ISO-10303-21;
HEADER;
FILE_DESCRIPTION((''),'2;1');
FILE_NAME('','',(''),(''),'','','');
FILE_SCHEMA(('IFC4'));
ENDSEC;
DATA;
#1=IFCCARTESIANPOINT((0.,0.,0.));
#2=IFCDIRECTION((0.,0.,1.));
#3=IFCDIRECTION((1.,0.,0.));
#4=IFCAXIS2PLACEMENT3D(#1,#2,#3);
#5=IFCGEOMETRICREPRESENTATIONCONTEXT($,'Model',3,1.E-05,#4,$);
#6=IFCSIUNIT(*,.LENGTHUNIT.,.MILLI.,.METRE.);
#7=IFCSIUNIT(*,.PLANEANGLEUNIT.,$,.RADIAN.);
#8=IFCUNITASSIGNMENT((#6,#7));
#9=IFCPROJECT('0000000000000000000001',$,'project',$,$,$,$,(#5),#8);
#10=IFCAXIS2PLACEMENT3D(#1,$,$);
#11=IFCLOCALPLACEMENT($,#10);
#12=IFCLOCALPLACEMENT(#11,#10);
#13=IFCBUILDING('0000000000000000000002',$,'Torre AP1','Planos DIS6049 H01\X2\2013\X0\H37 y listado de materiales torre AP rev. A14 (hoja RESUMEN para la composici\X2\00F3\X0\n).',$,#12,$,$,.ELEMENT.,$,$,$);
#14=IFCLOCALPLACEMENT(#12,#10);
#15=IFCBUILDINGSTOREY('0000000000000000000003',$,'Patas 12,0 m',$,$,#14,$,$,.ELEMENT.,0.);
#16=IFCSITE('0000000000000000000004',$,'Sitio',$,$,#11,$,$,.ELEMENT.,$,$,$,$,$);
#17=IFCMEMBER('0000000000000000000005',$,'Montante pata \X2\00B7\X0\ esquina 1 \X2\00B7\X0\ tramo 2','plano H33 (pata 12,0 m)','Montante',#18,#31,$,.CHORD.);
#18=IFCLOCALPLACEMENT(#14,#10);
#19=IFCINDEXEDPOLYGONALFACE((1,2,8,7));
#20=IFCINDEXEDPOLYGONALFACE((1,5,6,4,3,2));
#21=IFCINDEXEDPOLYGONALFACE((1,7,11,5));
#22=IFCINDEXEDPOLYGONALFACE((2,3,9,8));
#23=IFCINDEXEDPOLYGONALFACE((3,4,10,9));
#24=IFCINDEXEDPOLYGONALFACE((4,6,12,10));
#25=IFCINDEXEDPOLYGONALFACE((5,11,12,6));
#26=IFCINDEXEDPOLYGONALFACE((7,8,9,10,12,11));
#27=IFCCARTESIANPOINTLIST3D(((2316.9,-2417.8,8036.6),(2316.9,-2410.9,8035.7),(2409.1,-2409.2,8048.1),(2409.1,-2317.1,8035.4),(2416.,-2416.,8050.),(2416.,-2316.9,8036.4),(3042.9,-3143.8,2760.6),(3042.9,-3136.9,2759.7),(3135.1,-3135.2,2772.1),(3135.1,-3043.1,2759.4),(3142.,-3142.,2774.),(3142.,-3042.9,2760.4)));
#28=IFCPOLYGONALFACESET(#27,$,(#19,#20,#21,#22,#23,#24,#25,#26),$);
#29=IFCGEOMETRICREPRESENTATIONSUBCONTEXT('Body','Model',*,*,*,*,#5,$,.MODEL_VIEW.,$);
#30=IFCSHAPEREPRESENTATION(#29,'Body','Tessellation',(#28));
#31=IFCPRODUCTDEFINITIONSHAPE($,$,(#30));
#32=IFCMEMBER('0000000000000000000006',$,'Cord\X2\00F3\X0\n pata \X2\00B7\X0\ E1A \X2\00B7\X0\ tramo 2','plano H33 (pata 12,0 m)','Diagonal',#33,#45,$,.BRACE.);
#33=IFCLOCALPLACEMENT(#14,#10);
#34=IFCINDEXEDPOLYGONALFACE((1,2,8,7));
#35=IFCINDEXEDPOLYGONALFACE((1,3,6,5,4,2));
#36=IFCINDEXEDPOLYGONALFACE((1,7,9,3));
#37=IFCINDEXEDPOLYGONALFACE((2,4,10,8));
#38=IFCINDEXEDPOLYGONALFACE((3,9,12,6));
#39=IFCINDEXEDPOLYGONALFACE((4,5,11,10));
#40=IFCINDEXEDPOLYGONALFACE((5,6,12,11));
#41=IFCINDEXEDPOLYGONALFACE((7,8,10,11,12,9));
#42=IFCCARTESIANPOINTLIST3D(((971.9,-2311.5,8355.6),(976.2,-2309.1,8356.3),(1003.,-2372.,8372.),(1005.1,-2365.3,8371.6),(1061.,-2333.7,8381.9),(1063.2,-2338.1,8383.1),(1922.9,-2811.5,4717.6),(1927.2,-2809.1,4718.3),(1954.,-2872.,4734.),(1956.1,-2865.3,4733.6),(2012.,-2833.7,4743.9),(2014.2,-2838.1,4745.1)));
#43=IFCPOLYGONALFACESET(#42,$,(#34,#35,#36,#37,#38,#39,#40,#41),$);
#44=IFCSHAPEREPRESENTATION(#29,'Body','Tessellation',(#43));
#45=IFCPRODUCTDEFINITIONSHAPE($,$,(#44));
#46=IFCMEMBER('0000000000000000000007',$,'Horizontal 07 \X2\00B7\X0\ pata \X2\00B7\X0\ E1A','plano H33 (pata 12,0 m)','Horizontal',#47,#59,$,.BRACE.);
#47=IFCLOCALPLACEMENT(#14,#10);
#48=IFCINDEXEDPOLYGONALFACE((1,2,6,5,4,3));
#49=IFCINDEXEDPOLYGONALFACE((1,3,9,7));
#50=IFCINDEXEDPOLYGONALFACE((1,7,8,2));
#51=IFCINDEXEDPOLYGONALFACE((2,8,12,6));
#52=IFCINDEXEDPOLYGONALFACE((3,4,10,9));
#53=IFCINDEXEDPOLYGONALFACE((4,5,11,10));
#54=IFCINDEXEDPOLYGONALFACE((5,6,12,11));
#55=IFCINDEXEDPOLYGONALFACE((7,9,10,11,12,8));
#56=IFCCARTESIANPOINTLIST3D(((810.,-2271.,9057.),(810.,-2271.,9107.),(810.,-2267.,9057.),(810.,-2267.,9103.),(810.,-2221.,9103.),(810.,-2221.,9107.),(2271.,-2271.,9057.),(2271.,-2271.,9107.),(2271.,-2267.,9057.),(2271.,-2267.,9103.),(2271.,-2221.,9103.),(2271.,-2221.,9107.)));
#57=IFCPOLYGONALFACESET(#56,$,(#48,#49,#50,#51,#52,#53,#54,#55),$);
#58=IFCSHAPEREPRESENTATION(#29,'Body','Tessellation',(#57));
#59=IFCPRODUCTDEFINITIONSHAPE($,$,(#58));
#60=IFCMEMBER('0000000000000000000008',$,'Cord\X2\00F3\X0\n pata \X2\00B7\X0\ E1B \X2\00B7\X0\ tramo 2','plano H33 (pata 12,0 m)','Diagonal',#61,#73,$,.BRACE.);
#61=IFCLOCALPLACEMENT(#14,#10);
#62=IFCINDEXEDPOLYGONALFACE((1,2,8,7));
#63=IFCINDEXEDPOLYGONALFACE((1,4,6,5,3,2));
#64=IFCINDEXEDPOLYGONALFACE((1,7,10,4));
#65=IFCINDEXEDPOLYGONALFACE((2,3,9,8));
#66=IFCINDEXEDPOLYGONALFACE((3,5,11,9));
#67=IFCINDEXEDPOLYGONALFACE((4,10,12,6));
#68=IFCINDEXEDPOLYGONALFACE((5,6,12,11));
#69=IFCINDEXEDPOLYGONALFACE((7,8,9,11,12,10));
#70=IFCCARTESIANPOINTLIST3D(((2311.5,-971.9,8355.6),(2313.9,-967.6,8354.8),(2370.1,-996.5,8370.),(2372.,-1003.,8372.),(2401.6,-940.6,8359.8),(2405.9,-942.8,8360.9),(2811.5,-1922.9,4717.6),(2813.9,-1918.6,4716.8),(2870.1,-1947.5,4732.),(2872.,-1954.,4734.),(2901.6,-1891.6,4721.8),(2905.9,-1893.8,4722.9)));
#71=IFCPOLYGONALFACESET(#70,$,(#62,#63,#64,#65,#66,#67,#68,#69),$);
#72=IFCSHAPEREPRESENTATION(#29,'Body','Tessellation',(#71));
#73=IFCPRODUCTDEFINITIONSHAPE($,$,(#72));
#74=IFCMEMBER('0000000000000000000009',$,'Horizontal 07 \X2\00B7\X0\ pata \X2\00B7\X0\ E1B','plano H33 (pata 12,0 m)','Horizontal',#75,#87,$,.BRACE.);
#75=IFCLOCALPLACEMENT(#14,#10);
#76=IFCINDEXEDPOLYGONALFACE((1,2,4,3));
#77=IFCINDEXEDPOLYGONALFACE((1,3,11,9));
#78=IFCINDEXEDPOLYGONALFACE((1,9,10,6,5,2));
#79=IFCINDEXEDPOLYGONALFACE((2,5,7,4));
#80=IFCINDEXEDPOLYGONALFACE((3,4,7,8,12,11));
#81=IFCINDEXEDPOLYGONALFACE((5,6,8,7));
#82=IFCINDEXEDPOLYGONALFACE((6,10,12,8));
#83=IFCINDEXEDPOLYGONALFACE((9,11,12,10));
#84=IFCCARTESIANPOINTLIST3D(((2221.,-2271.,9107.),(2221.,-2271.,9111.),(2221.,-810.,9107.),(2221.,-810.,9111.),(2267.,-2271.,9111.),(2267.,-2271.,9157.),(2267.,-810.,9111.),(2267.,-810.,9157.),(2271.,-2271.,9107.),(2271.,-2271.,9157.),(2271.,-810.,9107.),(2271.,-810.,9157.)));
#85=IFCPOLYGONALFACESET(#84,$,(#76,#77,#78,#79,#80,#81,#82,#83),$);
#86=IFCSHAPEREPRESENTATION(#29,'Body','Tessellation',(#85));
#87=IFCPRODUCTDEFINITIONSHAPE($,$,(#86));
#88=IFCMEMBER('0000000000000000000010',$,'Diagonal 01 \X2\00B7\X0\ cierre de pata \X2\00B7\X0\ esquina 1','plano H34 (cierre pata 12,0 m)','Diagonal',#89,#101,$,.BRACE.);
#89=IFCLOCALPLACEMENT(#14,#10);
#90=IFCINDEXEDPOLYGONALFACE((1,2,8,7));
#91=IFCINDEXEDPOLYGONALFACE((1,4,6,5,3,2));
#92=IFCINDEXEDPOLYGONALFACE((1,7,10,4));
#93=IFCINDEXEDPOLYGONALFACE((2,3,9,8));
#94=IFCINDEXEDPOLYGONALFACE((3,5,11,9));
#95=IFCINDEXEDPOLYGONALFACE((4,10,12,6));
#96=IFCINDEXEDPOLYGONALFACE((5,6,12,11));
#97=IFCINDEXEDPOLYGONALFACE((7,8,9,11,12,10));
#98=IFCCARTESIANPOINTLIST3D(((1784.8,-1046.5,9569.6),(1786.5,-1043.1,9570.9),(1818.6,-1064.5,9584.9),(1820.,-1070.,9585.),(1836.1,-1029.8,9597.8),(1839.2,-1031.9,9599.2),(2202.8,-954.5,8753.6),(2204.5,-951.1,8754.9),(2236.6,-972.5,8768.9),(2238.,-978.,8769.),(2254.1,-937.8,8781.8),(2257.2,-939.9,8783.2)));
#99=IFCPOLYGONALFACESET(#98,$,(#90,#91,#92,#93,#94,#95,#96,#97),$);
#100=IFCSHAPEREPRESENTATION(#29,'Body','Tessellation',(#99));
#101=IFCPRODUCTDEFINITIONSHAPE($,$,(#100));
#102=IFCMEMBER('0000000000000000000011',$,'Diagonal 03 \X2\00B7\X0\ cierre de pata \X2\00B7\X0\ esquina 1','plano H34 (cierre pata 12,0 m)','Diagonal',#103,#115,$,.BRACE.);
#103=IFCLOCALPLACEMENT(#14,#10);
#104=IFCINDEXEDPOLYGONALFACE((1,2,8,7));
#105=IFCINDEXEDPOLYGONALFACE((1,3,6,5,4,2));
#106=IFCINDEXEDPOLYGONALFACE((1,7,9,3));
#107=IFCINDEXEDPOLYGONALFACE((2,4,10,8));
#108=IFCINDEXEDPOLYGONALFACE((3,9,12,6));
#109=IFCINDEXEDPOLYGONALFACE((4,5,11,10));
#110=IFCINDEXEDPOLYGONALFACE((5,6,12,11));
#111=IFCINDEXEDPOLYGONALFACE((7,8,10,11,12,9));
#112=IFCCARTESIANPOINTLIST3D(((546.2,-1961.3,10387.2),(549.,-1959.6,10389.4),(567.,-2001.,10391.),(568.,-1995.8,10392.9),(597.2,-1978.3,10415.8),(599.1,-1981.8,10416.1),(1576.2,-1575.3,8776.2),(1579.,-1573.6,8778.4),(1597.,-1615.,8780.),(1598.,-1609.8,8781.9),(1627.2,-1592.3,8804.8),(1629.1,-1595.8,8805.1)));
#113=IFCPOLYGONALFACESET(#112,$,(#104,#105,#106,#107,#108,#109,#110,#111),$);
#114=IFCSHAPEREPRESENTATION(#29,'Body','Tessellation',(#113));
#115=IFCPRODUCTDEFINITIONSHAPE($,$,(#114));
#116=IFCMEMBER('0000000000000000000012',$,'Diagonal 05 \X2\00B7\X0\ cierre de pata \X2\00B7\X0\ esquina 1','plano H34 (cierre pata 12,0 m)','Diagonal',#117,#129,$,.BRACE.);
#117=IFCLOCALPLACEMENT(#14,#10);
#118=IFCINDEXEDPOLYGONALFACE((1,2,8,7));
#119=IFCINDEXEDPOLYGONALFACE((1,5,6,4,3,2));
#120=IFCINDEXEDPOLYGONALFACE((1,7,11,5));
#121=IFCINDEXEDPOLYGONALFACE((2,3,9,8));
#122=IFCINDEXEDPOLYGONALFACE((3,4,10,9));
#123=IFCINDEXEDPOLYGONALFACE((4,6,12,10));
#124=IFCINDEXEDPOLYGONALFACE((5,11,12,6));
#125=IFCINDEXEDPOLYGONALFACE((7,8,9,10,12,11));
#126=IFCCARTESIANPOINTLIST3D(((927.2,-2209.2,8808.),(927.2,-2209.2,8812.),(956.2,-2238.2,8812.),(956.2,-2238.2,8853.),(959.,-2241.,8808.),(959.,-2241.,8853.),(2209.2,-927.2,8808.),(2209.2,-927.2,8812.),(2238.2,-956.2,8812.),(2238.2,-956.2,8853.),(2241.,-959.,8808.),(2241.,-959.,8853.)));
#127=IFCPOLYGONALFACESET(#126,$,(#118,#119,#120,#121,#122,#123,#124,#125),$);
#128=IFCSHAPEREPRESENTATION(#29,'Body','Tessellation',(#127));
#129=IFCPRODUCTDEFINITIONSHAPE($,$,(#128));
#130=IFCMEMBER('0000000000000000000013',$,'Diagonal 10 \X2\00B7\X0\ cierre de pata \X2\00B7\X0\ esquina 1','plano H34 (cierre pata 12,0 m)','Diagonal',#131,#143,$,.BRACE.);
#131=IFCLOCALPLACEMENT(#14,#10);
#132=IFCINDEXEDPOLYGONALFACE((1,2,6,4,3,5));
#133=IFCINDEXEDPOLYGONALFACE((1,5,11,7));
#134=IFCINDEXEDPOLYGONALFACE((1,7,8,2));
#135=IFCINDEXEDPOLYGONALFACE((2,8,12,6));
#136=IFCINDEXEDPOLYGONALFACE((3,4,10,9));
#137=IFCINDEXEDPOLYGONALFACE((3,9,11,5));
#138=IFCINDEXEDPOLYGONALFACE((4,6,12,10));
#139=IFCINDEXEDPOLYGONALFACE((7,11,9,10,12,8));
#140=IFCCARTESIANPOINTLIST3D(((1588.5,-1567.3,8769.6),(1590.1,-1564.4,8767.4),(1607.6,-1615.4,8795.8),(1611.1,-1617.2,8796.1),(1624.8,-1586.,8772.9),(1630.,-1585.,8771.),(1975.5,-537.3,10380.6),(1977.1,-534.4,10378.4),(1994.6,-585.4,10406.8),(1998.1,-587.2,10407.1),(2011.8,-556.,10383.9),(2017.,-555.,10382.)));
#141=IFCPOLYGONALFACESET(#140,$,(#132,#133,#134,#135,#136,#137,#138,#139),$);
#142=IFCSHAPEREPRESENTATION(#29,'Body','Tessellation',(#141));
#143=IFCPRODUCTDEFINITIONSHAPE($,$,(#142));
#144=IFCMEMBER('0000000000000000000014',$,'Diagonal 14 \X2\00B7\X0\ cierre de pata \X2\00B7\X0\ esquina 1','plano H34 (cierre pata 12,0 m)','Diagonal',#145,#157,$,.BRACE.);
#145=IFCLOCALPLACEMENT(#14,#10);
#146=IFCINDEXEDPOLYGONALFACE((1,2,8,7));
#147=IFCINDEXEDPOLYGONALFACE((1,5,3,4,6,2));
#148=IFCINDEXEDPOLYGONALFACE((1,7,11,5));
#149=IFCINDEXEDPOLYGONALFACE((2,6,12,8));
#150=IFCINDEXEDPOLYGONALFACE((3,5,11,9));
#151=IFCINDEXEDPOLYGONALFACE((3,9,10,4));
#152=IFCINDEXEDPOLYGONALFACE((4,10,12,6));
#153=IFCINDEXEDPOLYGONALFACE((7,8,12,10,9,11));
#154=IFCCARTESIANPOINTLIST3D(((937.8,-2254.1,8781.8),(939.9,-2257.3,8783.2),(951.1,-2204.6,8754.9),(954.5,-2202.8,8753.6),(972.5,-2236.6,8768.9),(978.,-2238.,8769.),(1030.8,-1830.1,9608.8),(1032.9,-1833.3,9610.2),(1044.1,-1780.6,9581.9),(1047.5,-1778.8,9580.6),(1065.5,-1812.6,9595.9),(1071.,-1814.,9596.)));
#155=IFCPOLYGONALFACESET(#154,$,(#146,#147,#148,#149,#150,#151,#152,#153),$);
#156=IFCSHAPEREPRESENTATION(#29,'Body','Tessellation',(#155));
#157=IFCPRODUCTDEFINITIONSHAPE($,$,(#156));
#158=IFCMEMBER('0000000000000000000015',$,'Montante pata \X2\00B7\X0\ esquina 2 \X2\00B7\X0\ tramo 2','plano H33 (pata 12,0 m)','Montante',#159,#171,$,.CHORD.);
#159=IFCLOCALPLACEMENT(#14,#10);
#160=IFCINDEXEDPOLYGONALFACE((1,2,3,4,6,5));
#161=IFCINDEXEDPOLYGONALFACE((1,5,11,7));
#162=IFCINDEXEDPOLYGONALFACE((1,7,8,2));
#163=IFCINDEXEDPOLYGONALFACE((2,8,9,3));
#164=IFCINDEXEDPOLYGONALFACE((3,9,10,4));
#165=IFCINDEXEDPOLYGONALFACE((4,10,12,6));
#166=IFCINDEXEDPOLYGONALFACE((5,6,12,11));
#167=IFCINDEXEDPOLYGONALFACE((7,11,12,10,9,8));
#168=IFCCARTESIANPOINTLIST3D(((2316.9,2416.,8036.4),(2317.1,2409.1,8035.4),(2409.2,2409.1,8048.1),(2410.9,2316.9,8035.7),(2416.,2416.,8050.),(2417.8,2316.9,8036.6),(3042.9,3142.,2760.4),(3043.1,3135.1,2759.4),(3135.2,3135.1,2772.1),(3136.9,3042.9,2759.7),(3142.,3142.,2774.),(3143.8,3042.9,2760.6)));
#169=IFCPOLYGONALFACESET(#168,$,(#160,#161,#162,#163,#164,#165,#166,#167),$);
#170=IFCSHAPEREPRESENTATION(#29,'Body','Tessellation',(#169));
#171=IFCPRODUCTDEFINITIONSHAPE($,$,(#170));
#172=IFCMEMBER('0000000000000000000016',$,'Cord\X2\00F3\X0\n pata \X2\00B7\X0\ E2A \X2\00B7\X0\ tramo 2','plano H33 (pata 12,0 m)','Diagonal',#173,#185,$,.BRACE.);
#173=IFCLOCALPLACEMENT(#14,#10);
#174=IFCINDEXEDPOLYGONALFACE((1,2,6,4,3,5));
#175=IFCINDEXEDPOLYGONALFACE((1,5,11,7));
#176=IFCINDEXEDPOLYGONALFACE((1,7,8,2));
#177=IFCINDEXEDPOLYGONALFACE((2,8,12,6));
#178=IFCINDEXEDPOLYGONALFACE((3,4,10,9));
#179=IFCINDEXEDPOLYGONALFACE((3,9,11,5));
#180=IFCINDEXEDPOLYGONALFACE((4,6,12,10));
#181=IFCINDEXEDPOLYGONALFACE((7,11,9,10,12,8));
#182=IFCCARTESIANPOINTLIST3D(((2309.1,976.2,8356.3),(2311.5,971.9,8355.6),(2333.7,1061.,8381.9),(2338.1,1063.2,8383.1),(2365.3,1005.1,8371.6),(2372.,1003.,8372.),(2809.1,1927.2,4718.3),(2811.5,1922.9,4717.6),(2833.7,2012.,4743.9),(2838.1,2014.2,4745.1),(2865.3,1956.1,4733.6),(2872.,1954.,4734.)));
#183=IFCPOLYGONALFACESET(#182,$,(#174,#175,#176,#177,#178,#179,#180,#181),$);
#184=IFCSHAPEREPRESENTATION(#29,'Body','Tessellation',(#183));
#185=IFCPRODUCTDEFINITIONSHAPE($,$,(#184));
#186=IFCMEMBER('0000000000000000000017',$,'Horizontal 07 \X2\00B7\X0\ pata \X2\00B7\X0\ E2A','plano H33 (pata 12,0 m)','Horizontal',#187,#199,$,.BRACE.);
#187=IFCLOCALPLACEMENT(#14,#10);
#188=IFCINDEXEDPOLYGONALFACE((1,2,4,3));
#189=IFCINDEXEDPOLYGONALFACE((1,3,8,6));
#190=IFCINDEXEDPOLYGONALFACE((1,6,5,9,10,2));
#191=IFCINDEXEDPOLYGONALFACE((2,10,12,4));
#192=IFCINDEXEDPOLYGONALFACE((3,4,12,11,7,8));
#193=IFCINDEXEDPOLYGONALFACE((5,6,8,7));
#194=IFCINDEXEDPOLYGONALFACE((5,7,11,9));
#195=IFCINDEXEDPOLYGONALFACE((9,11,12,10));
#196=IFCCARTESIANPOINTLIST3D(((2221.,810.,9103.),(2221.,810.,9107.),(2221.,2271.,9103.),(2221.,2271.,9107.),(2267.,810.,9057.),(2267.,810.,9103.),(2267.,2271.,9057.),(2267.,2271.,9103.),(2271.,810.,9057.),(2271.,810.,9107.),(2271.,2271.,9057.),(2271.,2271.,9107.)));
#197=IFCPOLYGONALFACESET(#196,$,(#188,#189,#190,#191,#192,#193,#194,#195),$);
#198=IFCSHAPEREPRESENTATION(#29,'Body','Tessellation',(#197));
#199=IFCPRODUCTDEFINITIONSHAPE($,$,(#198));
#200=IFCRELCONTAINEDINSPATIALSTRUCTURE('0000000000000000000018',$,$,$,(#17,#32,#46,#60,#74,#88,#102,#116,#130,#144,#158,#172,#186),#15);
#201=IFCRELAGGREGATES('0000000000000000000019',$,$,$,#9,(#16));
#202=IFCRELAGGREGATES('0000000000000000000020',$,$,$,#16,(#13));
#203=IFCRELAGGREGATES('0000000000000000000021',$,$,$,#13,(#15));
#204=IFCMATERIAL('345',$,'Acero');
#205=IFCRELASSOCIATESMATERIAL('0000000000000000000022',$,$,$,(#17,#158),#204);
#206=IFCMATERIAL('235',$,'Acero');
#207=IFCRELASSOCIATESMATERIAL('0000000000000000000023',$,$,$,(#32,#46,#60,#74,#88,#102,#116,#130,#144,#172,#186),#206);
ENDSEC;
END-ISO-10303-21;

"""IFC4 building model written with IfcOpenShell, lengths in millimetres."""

from ifc_helpers import new_model, si_unit, frame, frame_2d, origin, origin_with_axes, place, context, subcontext, project, spatial, l_section, extrude, material, element, save


model = new_model("IFC4")

# Units and contexts
model_context = context("Model", 3, precision=1e-05, world=origin_with_axes())
body_context = subcontext(model_context, "Body", "Model", "MODEL_VIEW")
ifc_project = project(units=[si_unit("LENGTHUNIT", "METRE", prefix="MILLI"), si_unit("PLANEANGLEUNIT", "RADIAN")], contexts=[model_context])

# Site, building, storey
site_placement = place(None, origin())
site = spatial("IfcSite", under=ifc_project, at=site_placement, Name="Sitio", CompositionType="ELEMENT")
building_placement = place(site_placement, origin())
building = spatial("IfcBuilding", under=site, at=building_placement, Name="Torre AP1", Description="Planos DIS6049 H01–H37 y listado de materiales torre AP rev. A14 (hoja RESUMEN para la composición).", CompositionType="ELEMENT")
storey_placement = place(building_placement, origin())
storey = spatial("IfcBuildingStorey", under=building, at=storey_placement, Name="Patas 12,0 m", CompositionType="ELEMENT", Elevation=0.0)

# Members
ifc_material_1 = material(Name="345", Category="Acero")
member_1_placement = place(storey_placement, frame((2416.0, -2416.0, 8050.0), z_axis=(0.13507, -0.13507, -0.981586), x_axis=(-0.990836, -0.018413, -0.13381)))
element("IfcMember", 1, at=member_1_placement, inside=storey, material=ifc_material_1, Name="Montante pata · esquina 1 · tramo 2", Description="plano H33 (pata 12,0 m)", ObjectType="Montante", PredefinedType="CHORD", context=body_context, shape_type="SweptSolid", body=[
    extrude(l_section(Depth=100.0, Width=100.0, Thickness=7.0, at=frame_2d((50.0, 50.0))), None, (0.0, 0.0, 1.0), 5375.0),
])
ifc_material_2 = material(Name="235", Category="Acero")
member_2_placement = place(storey_placement, frame((1003.0, -2372.0, 8372.0), z_axis=(0.250702, -0.13181, -0.959049), x_axis=(-0.444282, 0.864528, -0.234958)))
element("IfcMember", 2, at=member_2_placement, inside=storey, material=ifc_material_2, Name="Cordón pata · E1A · tramo 2", Description="plano H33 (pata 12,0 m)", ObjectType="Diagonal", PredefinedType="BRACE", context=body_context, shape_type="SweptSolid", body=[
    extrude(l_section(Depth=70.0, Width=70.0, Thickness=5.0, at=frame_2d((35.0, 35.0))), None, (0.0, 0.0, 1.0), 3793.3),
])
member_3_placement = place(storey_placement, frame((2271.0, -2271.0, 9107.0), z_axis=(-1.0, 0.0, 0.0), x_axis=(0.0, 1.0, 0.0)))
element("IfcMember", 3, at=member_3_placement, inside=storey, material=ifc_material_2, Name="Horizontal 07 · pata · E1A", Description="plano H33 (pata 12,0 m)", ObjectType="Horizontal", PredefinedType="BRACE", context=body_context, shape_type="SweptSolid", body=[
    extrude(l_section(Depth=50.0, Width=50.0, Thickness=4.0, at=frame_2d((25.0, 25.0))), None, (0.0, 0.0, 1.0), 1461.0),
])
member_4_placement = place(storey_placement, frame((2372.0, -1003.0, 8372.0), z_axis=(0.13181, -0.250702, -0.959049), x_axis=(-0.864528, 0.444282, -0.234958)))
element("IfcMember", 4, at=member_4_placement, inside=storey, material=ifc_material_2, Name="Cordón pata · E1B · tramo 2", Description="plano H33 (pata 12,0 m)", ObjectType="Diagonal", PredefinedType="BRACE", context=body_context, shape_type="SweptSolid", body=[
    extrude(l_section(Depth=70.0, Width=70.0, Thickness=5.0, at=frame_2d((35.0, 35.0))), None, (0.0, 0.0, 1.0), 3793.3),
])
member_5_placement = place(storey_placement, frame((2271.0, -2271.0, 9107.0), z_axis=(0.0, 1.0, 0.0), x_axis=(-1.0, 0.0, 0.0)))
element("IfcMember", 5, at=member_5_placement, inside=storey, material=ifc_material_2, Name="Horizontal 07 · pata · E1B", Description="plano H33 (pata 12,0 m)", ObjectType="Horizontal", PredefinedType="BRACE", context=body_context, shape_type="SweptSolid", body=[
    extrude(l_section(Depth=50.0, Width=50.0, Thickness=4.0, at=frame_2d((25.0, 25.0))), None, (0.0, 0.0, 1.0), 1461.0),
])
member_6_placement = place(storey_placement, frame((1820.0, -1070.0, 9585.0), z_axis=(0.45364, 0.099844, -0.885574), x_axis=(-0.78186, 0.521462, -0.34172)))
element("IfcMember", 6, at=member_6_placement, inside=storey, material=ifc_material_2, Name="Diagonal 01 · cierre de pata · esquina 1", Description="plano H34 (cierre pata 12,0 m)", ObjectType="Diagonal", PredefinedType="BRACE", context=body_context, shape_type="SweptSolid", body=[
    extrude(l_section(Depth=45.0, Width=45.0, Thickness=4.0, at=frame_2d((22.5, 22.5))), None, (0.0, 0.0, 1.0), 921.4),
])
member_7_placement = place(storey_placement, frame((567.0, -2001.0, 10391.0), z_axis=(0.528017, 0.197878, -0.825859), x_axis=(-0.462384, 0.882679, -0.084135)))
element("IfcMember", 7, at=member_7_placement, inside=storey, material=ifc_material_2, Name="Diagonal 03 · cierre de pata · esquina 1", Description="plano H34 (cierre pata 12,0 m)", ObjectType="Diagonal", PredefinedType="BRACE", context=body_context, shape_type="SweptSolid", body=[
    extrude(l_section(Depth=45.0, Width=45.0, Thickness=4.0, at=frame_2d((22.5, 22.5))), None, (0.0, 0.0, 1.0), 1950.7),
])
member_8_placement = place(storey_placement, frame((959.0, -2241.0, 8808.0), z_axis=(0.707107, 0.707107, 0.0), x_axis=(-0.707107, 0.707107, 0.0)))
element("IfcMember", 8, at=member_8_placement, inside=storey, material=ifc_material_2, Name="Diagonal 05 · cierre de pata · esquina 1", Description="plano H34 (cierre pata 12,0 m)", ObjectType="Diagonal", PredefinedType="BRACE", context=body_context, shape_type="SweptSolid", body=[
    extrude(l_section(Depth=45.0, Width=45.0, Thickness=4.0, at=frame_2d((22.5, 22.5))), None, (0.0, 0.0, 1.0), 1813.0),
])
member_9_placement = place(storey_placement, frame((1630.0, -1585.0, 8771.0), z_axis=(0.198371, 0.527963, 0.825775), x_axis=(-0.885645, 0.457467, -0.079731)))
element("IfcMember", 9, at=member_9_placement, inside=storey, material=ifc_material_2, Name="Diagonal 10 · cierre de pata · esquina 1", Description="plano H34 (cierre pata 12,0 m)", ObjectType="Diagonal", PredefinedType="BRACE", context=body_context, shape_type="SweptSolid", body=[
    extrude(l_section(Depth=45.0, Width=45.0, Thickness=4.0, at=frame_2d((22.5, 22.5))), None, (0.0, 0.0, 1.0), 1950.9),
])
member_10_placement = place(storey_placement, frame((978.0, -2238.0, 8769.0), z_axis=(0.099572, 0.453962, 0.88544), x_axis=(-0.522172, 0.781324, -0.341862)))
element("IfcMember", 10, at=member_10_placement, inside=storey, material=ifc_material_2, Name="Diagonal 14 · cierre de pata · esquina 1", Description="plano H34 (cierre pata 12,0 m)", ObjectType="Diagonal", PredefinedType="BRACE", context=body_context, shape_type="SweptSolid", body=[
    extrude(l_section(Depth=45.0, Width=45.0, Thickness=4.0, at=frame_2d((22.5, 22.5))), None, (0.0, 0.0, 1.0), 934.0),
])
member_11_placement = place(storey_placement, frame((2416.0, 2416.0, 8050.0), z_axis=(0.13507, 0.13507, -0.981586), x_axis=(0.018413, -0.990836, -0.13381)))
element("IfcMember", 11, at=member_11_placement, inside=storey, material=ifc_material_1, Name="Montante pata · esquina 2 · tramo 2", Description="plano H33 (pata 12,0 m)", ObjectType="Montante", PredefinedType="CHORD", context=body_context, shape_type="SweptSolid", body=[
    extrude(l_section(Depth=100.0, Width=100.0, Thickness=7.0, at=frame_2d((50.0, 50.0))), None, (0.0, 0.0, 1.0), 5375.0),
])
member_12_placement = place(storey_placement, frame((2372.0, 1003.0, 8372.0), z_axis=(0.13181, 0.250702, -0.959049), x_axis=(-0.864528, -0.444282, -0.234958)))
element("IfcMember", 12, at=member_12_placement, inside=storey, material=ifc_material_2, Name="Cordón pata · E2A · tramo 2", Description="plano H33 (pata 12,0 m)", ObjectType="Diagonal", PredefinedType="BRACE", context=body_context, shape_type="SweptSolid", body=[
    extrude(l_section(Depth=70.0, Width=70.0, Thickness=5.0, at=frame_2d((35.0, 35.0))), None, (0.0, 0.0, 1.0), 3793.3),
])
member_13_placement = place(storey_placement, frame((2271.0, 2271.0, 9107.0), z_axis=(0.0, -1.0, 0.0), x_axis=(-1.0, 0.0, 0.0)))
element("IfcMember", 13, at=member_13_placement, inside=storey, material=ifc_material_2, Name="Horizontal 07 · pata · E2A", Description="plano H33 (pata 12,0 m)", ObjectType="Horizontal", PredefinedType="BRACE", context=body_context, shape_type="SweptSolid", body=[
    extrude(l_section(Depth=50.0, Width=50.0, Thickness=4.0, at=frame_2d((25.0, 25.0))), None, (0.0, 0.0, 1.0), 1461.0),
])

save(model, "model.ifc")
